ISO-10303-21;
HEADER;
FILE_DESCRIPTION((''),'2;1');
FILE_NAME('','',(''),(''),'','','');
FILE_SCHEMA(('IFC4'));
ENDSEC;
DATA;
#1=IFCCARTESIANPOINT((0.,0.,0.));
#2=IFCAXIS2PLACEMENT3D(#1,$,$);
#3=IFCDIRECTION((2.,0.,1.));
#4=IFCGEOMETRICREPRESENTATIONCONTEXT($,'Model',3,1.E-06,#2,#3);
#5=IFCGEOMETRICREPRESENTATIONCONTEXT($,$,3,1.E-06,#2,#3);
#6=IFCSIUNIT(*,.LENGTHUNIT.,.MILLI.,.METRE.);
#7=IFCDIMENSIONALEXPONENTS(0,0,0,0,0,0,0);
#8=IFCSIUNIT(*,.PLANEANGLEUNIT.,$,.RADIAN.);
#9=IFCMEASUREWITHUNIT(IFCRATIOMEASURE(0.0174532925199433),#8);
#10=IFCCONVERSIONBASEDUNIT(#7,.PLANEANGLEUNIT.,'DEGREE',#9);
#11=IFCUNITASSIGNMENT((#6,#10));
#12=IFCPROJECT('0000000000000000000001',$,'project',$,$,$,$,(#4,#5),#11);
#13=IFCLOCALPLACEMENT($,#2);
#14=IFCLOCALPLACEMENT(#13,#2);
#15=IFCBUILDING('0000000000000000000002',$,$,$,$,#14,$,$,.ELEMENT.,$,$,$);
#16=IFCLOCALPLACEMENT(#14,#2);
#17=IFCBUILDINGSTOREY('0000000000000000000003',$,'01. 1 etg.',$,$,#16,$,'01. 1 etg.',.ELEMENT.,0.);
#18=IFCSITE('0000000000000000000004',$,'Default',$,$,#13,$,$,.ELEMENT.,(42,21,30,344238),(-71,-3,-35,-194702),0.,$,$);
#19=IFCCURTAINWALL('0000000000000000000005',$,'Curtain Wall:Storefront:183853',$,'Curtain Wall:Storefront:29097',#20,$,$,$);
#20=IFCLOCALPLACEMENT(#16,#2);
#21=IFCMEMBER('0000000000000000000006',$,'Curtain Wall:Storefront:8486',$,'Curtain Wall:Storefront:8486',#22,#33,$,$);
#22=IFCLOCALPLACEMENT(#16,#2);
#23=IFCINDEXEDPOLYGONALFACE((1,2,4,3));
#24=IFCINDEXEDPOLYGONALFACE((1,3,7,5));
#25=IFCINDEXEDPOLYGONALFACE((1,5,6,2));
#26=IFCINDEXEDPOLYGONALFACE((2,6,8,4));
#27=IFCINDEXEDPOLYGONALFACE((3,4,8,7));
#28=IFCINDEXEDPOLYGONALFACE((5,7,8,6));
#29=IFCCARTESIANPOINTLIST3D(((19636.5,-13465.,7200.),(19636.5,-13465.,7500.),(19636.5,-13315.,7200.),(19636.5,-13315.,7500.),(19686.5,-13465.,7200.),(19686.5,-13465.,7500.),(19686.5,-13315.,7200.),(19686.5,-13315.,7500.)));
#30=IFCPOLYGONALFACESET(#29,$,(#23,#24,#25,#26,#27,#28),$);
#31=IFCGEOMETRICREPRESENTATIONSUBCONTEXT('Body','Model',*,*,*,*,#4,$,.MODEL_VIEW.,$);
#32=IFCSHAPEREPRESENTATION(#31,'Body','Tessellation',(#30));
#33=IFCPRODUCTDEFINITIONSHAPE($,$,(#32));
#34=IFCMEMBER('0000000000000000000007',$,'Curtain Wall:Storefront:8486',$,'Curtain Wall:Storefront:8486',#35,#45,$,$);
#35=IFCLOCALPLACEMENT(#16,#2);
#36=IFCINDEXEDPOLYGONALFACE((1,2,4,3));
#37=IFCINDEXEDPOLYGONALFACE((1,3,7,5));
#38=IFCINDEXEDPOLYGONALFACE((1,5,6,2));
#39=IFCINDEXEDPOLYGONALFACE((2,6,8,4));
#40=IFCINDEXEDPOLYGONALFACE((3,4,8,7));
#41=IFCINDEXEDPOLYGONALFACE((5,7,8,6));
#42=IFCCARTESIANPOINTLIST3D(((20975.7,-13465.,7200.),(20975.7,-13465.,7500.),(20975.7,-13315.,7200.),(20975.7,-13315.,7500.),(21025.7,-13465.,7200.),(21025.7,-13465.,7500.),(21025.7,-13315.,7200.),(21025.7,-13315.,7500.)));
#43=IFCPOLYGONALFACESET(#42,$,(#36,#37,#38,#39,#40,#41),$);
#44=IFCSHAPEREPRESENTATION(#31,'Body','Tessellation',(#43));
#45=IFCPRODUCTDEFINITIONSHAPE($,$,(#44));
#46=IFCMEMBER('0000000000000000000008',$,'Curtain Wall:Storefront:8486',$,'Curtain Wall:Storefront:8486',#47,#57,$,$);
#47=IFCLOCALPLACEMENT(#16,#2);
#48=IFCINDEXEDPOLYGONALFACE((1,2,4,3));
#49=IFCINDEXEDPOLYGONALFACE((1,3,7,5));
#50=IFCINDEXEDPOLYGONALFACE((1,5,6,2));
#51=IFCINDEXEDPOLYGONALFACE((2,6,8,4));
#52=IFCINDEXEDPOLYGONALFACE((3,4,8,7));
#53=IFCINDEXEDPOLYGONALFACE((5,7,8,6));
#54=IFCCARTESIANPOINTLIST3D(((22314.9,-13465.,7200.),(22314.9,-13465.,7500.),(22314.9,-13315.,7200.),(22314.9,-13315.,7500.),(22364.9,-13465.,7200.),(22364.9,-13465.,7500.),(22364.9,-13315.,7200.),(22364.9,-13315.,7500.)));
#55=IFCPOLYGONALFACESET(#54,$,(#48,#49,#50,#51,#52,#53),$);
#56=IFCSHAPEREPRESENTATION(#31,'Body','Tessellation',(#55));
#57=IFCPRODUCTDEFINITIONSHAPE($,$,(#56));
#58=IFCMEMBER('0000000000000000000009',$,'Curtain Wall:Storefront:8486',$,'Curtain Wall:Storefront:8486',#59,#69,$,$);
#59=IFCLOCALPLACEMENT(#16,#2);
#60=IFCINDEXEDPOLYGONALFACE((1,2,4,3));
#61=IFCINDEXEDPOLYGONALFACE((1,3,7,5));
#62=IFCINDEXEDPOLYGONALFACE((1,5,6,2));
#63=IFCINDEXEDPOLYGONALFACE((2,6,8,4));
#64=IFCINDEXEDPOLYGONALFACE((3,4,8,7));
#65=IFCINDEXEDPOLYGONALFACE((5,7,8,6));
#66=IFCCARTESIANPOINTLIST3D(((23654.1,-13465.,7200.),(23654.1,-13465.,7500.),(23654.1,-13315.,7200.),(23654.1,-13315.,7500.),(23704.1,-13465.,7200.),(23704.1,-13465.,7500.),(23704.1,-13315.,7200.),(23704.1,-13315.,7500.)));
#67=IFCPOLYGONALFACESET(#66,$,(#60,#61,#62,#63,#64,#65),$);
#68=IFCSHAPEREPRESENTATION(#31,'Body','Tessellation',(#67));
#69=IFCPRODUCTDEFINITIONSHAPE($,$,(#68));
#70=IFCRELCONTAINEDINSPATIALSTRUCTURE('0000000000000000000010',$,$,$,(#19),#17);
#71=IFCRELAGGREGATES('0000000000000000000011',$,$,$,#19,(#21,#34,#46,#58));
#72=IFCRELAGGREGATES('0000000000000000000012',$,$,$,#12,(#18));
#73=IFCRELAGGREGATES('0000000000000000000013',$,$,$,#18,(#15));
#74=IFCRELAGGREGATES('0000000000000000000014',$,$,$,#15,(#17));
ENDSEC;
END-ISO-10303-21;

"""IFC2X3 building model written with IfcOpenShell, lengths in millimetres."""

from ifc_helpers import new_model, entity, si_unit, converted_unit, direction, frame, frame_2d, origin, place, context, subcontext, project, spatial, rectangle, extrude, element, aggregate, save


model = new_model("IFC2X3")

# Units and contexts
model_context = context("Model", 3, precision=1e-06, world=origin(), true_north=direction((2.0, 0.0, 1.0)))
context_of_model = context(None, 3, precision=1e-06, world=origin(), true_north=direction((2.0, 0.0, 1.0)))
body_context = subcontext(model_context, "Body", "Model", "MODEL_VIEW")
ifc_project = project(units=[si_unit("LENGTHUNIT", "METRE", prefix="MILLI"), converted_unit("PLANEANGLEUNIT", "DEGREE", entity("IfcRatioMeasure", 0.0174532925199433), si_unit("PLANEANGLEUNIT", "RADIAN"), dimensions=[0, 0, 0, 0, 0, 0, 0])], contexts=[model_context, context_of_model])

# Site, building, storey
site_placement = place(None, origin())
site = spatial("IfcSite", under=ifc_project, at=site_placement, Name="Default", CompositionType="ELEMENT", RefLatitude=(42, 21, 30, 344238), RefLongitude=(-71, -3, -35, -194702), RefElevation=0.0)
building_placement = place(site_placement, origin())
building = spatial("IfcBuilding", under=site, at=building_placement, CompositionType="ELEMENT")
storey_placement = place(building_placement, origin())
storey = spatial("IfcBuildingStorey", under=building, at=storey_placement, Name="01. 1 etg.", LongName="01. 1 etg.", CompositionType="ELEMENT", Elevation=0.0)

# Curtain wall, members
curtain_wall_placement = place(storey_placement, origin())
curtain_wall = element("IfcCurtainWall", 1, at=curtain_wall_placement, inside=storey, Name="Curtain Wall:Storefront:183853", ObjectType="Curtain Wall:Storefront:29097")
member_1_placement = place(storey_placement, origin())
member_1 = element("IfcMember", 2, at=member_1_placement, Name="Curtain Wall:Storefront:8486", ObjectType="Curtain Wall:Storefront:8486", context=body_context, shape_type="SweptSolid", body=[
    extrude(rectangle(XDim=150.0, YDim=50.0, at=frame_2d((0.0, 0.0), x_axis=(1.0, 0.0))), frame((19661.5, -13390.0, 7200.0), z_axis=(0.0, 0.0, 1.0), x_axis=(0.0, 1.0, 0.0)), (0.0, 0.0, 1.0), 300.0),
])
member_2_placement = place(storey_placement, origin())
member_2 = element("IfcMember", 3, at=member_2_placement, Name="Curtain Wall:Storefront:8486", ObjectType="Curtain Wall:Storefront:8486", context=body_context, shape_type="SweptSolid", body=[
    extrude(rectangle(XDim=150.0, YDim=50.0, at=frame_2d((0.0, 0.0), x_axis=(1.0, 0.0))), frame((21000.7, -13390.0, 7200.0), z_axis=(0.0, 0.0, 1.0), x_axis=(0.0, 1.0, 0.0)), (0.0, 0.0, 1.0), 300.0),
])
member_3_placement = place(storey_placement, origin())
member_3 = element("IfcMember", 4, at=member_3_placement, Name="Curtain Wall:Storefront:8486", ObjectType="Curtain Wall:Storefront:8486", context=body_context, shape_type="SweptSolid", body=[
    extrude(rectangle(XDim=150.0, YDim=50.0, at=frame_2d((0.0, 0.0), x_axis=(1.0, 0.0))), frame((22339.9, -13390.0, 7200.0), z_axis=(0.0, 0.0, 1.0), x_axis=(0.0, 1.0, 0.0)), (0.0, 0.0, 1.0), 300.0),
])
member_4_placement = place(storey_placement, origin())
member_4 = element("IfcMember", 5, at=member_4_placement, Name="Curtain Wall:Storefront:8486", ObjectType="Curtain Wall:Storefront:8486", context=body_context, shape_type="SweptSolid", body=[
    extrude(rectangle(XDim=150.0, YDim=50.0, at=frame_2d((0.0, 0.0), x_axis=(1.0, 0.0))), frame((23679.1, -13390.0, 7200.0), z_axis=(0.0, 0.0, 1.0), x_axis=(0.0, 1.0, 0.0)), (0.0, 0.0, 1.0), 300.0),
])
aggregate(curtain_wall, [member_1, member_2, member_3, member_4])

save(model, "model.ifc")
